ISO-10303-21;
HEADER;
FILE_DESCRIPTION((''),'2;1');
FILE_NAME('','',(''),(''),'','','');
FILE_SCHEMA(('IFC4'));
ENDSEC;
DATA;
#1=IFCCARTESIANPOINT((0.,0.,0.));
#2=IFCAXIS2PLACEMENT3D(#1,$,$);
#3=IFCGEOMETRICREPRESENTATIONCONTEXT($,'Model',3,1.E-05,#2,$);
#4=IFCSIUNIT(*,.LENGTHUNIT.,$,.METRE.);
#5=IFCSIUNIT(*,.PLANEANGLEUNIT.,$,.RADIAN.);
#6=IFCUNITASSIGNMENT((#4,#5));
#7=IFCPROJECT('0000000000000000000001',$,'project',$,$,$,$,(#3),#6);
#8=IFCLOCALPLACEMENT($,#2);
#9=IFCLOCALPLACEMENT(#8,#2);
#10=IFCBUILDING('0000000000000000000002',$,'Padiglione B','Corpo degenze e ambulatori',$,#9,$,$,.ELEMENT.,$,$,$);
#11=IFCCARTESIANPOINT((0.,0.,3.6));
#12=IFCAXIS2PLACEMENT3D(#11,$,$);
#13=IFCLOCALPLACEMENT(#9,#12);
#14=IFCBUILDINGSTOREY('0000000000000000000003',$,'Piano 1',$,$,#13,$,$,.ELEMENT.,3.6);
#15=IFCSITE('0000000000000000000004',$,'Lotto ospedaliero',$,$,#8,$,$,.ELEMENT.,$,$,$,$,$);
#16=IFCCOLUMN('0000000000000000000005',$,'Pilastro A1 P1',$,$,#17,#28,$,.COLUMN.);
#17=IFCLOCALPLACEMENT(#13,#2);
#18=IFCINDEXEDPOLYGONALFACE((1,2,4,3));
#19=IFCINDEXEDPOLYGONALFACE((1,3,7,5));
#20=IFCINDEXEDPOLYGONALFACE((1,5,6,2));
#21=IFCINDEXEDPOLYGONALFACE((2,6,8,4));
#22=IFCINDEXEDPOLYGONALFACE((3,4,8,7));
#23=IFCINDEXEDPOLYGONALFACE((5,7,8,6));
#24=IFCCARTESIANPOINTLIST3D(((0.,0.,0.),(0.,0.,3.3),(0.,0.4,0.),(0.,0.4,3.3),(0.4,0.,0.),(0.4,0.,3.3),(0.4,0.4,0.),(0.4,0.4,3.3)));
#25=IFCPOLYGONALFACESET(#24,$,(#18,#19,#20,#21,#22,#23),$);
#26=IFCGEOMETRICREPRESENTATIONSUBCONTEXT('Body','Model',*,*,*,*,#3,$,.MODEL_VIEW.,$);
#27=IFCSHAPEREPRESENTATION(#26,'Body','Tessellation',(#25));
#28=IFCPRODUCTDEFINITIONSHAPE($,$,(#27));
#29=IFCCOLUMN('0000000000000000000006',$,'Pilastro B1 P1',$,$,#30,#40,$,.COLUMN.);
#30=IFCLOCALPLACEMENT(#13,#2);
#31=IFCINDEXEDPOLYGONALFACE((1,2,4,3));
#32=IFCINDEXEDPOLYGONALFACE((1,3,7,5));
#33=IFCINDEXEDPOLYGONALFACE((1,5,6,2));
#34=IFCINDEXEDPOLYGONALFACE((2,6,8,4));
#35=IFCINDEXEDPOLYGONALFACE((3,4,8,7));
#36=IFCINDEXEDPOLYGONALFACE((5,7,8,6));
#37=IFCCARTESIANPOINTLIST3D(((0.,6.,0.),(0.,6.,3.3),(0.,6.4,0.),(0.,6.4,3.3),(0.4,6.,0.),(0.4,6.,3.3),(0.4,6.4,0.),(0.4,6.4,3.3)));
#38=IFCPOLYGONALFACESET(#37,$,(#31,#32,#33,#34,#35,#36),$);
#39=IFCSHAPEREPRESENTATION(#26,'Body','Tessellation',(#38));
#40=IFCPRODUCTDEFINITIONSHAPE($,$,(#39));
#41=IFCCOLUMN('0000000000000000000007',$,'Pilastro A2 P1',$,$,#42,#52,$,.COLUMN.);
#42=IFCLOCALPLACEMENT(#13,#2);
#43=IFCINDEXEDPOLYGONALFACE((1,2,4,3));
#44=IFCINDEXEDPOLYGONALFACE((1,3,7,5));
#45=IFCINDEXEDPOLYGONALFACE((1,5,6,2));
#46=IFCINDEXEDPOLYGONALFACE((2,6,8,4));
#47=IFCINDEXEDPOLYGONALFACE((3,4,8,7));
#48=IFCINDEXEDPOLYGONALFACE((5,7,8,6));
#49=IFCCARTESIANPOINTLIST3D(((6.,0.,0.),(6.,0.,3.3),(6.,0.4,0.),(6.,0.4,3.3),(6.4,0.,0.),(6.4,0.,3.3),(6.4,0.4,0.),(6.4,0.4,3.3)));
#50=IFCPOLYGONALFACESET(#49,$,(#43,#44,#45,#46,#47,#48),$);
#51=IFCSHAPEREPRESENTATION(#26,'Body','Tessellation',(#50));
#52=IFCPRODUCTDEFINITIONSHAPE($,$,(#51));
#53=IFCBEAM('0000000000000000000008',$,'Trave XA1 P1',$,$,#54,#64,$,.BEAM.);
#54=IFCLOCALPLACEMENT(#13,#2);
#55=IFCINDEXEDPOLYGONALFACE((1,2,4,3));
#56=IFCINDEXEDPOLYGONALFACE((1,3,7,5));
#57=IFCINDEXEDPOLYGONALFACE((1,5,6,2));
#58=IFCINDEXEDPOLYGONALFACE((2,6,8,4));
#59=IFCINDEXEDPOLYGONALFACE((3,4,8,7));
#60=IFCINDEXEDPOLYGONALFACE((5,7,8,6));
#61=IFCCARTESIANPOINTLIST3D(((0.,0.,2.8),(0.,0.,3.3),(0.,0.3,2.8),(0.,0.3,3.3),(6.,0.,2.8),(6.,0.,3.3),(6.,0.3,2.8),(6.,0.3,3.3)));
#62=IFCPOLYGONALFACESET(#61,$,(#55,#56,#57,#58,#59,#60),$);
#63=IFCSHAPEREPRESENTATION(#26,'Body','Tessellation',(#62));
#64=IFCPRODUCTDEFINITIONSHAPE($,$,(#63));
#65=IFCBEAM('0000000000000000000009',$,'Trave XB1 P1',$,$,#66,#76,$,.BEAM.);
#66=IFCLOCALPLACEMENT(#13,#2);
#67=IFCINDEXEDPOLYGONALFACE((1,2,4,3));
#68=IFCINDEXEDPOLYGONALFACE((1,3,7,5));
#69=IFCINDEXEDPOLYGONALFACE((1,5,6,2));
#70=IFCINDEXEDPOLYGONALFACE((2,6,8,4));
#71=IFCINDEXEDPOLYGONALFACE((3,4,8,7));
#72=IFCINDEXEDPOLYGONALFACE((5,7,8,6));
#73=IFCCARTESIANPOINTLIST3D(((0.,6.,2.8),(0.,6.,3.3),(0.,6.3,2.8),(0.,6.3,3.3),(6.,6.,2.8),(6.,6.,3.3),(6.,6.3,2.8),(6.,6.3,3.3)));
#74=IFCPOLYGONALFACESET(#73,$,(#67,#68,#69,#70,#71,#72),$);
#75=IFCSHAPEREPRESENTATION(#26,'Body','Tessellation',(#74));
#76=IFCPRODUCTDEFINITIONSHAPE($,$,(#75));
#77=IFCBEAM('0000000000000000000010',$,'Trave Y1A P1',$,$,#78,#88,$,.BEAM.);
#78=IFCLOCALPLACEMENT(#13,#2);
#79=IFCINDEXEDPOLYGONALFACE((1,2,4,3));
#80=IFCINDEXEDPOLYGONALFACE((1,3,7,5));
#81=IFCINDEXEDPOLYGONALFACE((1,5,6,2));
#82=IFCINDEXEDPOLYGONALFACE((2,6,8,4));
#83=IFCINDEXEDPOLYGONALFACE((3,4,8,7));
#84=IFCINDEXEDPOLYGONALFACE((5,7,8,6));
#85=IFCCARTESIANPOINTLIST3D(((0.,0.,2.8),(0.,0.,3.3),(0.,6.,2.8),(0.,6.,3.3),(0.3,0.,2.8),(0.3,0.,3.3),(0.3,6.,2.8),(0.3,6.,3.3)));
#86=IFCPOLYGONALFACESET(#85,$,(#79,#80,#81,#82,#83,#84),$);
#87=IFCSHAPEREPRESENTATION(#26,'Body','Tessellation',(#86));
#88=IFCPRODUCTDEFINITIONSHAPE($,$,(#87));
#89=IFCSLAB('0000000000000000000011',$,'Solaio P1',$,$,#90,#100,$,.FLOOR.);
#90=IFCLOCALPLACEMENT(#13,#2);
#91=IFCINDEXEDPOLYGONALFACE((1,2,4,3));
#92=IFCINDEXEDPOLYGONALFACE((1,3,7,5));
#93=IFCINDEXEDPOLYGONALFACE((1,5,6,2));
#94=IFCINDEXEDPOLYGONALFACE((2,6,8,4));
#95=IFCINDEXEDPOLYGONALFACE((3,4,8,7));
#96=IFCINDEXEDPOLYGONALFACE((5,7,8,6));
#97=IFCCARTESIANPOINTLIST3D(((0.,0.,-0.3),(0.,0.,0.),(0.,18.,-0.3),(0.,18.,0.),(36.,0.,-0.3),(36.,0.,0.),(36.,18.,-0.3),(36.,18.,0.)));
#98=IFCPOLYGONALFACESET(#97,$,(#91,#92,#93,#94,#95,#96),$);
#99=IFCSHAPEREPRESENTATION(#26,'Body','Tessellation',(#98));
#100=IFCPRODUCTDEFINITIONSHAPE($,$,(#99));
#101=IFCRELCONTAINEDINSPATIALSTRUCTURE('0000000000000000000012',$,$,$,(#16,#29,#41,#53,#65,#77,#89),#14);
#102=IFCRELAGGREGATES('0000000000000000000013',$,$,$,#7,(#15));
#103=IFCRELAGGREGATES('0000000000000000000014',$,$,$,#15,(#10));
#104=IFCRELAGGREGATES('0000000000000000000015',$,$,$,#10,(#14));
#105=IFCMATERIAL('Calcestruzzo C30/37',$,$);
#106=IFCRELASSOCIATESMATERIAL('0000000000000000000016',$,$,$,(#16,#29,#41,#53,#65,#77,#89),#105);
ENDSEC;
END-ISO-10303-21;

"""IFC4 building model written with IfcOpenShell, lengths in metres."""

from ifc_helpers import new_model, si_unit, frame, frame_2d, origin, place, context, subcontext, project, spatial, rectangle, extrude, material, element, save


model = new_model("IFC4")

# Units and contexts
model_context = context("Model", 3, precision=1e-05, world=origin())
body_context = subcontext(model_context, "Body", "Model", "MODEL_VIEW")
ifc_project = project(units=[si_unit("LENGTHUNIT", "METRE"), si_unit("PLANEANGLEUNIT", "RADIAN")], contexts=[model_context])

# Site, building, storey
site_placement = place(None, origin())
site = spatial("IfcSite", under=ifc_project, at=site_placement, Name="Lotto ospedaliero", CompositionType="ELEMENT")
building_placement = place(site_placement, origin())
building = spatial("IfcBuilding", under=site, at=building_placement, Name="Padiglione B", Description="Corpo degenze e ambulatori", CompositionType="ELEMENT")
storey_placement = place(building_placement, frame((0.0, 0.0, 3.6)))
storey = spatial("IfcBuildingStorey", under=building, at=storey_placement, Name="Piano 1", CompositionType="ELEMENT", Elevation=3.6)

# Columns
ifc_material_1 = material(Name="Calcestruzzo C30/37")
for number, where, name in (
    (1, (0.0, 0.0, 0.0), "Pilastro A1 P1"),
    (2, (0.0, 6.0, 0.0), "Pilastro B1 P1"),
    (3, (6.0, 0.0, 0.0), "Pilastro A2 P1"),
):
    element("IfcColumn", number, at=place(storey_placement, frame(where)), inside=storey, material=ifc_material_1, Name=name, PredefinedType="COLUMN", context=body_context, shape_type="SweptSolid", body=[
        extrude(rectangle(XDim=0.4, YDim=0.4, at=frame_2d((0.2, 0.2))), origin(), (0.0, 0.0, 1.0), 3.3),
    ])

# Beams
for number, where, name in (
    (4, (0.0, 0.0, 2.8), "Trave XA1 P1"),
    (5, (0.0, 6.0, 2.8), "Trave XB1 P1"),
):
    element("IfcBeam", number, at=place(storey_placement, frame(where)), inside=storey, material=ifc_material_1, Name=name, PredefinedType="BEAM", context=body_context, shape_type="SweptSolid", body=[
        extrude(rectangle(XDim=6.0, YDim=0.3, at=frame_2d((3.0, 0.15))), origin(), (0.0, 0.0, 1.0), 0.5),
    ])
beam_placement = place(storey_placement, frame((0.0, 0.0, 2.8)))
element("IfcBeam", 6, at=beam_placement, inside=storey, material=ifc_material_1, Name="Trave Y1A P1", PredefinedType="BEAM", context=body_context, shape_type="SweptSolid", body=[
    extrude(rectangle(XDim=0.3, YDim=6.0, at=frame_2d((0.15, 3.0))), origin(), (0.0, 0.0, 1.0), 0.5),
])

# Slab
slab_placement = place(storey_placement, frame((0.0, 0.0, -0.3)))
element("IfcSlab", 7, at=slab_placement, inside=storey, material=ifc_material_1, Name="Solaio P1", PredefinedType="FLOOR", context=body_context, shape_type="SweptSolid", body=[
    extrude(rectangle(XDim=36.0, YDim=18.0, at=frame_2d((18.0, 9.0))), origin(), (0.0, 0.0, 1.0), 0.3),
])

save(model, "model.ifc")
